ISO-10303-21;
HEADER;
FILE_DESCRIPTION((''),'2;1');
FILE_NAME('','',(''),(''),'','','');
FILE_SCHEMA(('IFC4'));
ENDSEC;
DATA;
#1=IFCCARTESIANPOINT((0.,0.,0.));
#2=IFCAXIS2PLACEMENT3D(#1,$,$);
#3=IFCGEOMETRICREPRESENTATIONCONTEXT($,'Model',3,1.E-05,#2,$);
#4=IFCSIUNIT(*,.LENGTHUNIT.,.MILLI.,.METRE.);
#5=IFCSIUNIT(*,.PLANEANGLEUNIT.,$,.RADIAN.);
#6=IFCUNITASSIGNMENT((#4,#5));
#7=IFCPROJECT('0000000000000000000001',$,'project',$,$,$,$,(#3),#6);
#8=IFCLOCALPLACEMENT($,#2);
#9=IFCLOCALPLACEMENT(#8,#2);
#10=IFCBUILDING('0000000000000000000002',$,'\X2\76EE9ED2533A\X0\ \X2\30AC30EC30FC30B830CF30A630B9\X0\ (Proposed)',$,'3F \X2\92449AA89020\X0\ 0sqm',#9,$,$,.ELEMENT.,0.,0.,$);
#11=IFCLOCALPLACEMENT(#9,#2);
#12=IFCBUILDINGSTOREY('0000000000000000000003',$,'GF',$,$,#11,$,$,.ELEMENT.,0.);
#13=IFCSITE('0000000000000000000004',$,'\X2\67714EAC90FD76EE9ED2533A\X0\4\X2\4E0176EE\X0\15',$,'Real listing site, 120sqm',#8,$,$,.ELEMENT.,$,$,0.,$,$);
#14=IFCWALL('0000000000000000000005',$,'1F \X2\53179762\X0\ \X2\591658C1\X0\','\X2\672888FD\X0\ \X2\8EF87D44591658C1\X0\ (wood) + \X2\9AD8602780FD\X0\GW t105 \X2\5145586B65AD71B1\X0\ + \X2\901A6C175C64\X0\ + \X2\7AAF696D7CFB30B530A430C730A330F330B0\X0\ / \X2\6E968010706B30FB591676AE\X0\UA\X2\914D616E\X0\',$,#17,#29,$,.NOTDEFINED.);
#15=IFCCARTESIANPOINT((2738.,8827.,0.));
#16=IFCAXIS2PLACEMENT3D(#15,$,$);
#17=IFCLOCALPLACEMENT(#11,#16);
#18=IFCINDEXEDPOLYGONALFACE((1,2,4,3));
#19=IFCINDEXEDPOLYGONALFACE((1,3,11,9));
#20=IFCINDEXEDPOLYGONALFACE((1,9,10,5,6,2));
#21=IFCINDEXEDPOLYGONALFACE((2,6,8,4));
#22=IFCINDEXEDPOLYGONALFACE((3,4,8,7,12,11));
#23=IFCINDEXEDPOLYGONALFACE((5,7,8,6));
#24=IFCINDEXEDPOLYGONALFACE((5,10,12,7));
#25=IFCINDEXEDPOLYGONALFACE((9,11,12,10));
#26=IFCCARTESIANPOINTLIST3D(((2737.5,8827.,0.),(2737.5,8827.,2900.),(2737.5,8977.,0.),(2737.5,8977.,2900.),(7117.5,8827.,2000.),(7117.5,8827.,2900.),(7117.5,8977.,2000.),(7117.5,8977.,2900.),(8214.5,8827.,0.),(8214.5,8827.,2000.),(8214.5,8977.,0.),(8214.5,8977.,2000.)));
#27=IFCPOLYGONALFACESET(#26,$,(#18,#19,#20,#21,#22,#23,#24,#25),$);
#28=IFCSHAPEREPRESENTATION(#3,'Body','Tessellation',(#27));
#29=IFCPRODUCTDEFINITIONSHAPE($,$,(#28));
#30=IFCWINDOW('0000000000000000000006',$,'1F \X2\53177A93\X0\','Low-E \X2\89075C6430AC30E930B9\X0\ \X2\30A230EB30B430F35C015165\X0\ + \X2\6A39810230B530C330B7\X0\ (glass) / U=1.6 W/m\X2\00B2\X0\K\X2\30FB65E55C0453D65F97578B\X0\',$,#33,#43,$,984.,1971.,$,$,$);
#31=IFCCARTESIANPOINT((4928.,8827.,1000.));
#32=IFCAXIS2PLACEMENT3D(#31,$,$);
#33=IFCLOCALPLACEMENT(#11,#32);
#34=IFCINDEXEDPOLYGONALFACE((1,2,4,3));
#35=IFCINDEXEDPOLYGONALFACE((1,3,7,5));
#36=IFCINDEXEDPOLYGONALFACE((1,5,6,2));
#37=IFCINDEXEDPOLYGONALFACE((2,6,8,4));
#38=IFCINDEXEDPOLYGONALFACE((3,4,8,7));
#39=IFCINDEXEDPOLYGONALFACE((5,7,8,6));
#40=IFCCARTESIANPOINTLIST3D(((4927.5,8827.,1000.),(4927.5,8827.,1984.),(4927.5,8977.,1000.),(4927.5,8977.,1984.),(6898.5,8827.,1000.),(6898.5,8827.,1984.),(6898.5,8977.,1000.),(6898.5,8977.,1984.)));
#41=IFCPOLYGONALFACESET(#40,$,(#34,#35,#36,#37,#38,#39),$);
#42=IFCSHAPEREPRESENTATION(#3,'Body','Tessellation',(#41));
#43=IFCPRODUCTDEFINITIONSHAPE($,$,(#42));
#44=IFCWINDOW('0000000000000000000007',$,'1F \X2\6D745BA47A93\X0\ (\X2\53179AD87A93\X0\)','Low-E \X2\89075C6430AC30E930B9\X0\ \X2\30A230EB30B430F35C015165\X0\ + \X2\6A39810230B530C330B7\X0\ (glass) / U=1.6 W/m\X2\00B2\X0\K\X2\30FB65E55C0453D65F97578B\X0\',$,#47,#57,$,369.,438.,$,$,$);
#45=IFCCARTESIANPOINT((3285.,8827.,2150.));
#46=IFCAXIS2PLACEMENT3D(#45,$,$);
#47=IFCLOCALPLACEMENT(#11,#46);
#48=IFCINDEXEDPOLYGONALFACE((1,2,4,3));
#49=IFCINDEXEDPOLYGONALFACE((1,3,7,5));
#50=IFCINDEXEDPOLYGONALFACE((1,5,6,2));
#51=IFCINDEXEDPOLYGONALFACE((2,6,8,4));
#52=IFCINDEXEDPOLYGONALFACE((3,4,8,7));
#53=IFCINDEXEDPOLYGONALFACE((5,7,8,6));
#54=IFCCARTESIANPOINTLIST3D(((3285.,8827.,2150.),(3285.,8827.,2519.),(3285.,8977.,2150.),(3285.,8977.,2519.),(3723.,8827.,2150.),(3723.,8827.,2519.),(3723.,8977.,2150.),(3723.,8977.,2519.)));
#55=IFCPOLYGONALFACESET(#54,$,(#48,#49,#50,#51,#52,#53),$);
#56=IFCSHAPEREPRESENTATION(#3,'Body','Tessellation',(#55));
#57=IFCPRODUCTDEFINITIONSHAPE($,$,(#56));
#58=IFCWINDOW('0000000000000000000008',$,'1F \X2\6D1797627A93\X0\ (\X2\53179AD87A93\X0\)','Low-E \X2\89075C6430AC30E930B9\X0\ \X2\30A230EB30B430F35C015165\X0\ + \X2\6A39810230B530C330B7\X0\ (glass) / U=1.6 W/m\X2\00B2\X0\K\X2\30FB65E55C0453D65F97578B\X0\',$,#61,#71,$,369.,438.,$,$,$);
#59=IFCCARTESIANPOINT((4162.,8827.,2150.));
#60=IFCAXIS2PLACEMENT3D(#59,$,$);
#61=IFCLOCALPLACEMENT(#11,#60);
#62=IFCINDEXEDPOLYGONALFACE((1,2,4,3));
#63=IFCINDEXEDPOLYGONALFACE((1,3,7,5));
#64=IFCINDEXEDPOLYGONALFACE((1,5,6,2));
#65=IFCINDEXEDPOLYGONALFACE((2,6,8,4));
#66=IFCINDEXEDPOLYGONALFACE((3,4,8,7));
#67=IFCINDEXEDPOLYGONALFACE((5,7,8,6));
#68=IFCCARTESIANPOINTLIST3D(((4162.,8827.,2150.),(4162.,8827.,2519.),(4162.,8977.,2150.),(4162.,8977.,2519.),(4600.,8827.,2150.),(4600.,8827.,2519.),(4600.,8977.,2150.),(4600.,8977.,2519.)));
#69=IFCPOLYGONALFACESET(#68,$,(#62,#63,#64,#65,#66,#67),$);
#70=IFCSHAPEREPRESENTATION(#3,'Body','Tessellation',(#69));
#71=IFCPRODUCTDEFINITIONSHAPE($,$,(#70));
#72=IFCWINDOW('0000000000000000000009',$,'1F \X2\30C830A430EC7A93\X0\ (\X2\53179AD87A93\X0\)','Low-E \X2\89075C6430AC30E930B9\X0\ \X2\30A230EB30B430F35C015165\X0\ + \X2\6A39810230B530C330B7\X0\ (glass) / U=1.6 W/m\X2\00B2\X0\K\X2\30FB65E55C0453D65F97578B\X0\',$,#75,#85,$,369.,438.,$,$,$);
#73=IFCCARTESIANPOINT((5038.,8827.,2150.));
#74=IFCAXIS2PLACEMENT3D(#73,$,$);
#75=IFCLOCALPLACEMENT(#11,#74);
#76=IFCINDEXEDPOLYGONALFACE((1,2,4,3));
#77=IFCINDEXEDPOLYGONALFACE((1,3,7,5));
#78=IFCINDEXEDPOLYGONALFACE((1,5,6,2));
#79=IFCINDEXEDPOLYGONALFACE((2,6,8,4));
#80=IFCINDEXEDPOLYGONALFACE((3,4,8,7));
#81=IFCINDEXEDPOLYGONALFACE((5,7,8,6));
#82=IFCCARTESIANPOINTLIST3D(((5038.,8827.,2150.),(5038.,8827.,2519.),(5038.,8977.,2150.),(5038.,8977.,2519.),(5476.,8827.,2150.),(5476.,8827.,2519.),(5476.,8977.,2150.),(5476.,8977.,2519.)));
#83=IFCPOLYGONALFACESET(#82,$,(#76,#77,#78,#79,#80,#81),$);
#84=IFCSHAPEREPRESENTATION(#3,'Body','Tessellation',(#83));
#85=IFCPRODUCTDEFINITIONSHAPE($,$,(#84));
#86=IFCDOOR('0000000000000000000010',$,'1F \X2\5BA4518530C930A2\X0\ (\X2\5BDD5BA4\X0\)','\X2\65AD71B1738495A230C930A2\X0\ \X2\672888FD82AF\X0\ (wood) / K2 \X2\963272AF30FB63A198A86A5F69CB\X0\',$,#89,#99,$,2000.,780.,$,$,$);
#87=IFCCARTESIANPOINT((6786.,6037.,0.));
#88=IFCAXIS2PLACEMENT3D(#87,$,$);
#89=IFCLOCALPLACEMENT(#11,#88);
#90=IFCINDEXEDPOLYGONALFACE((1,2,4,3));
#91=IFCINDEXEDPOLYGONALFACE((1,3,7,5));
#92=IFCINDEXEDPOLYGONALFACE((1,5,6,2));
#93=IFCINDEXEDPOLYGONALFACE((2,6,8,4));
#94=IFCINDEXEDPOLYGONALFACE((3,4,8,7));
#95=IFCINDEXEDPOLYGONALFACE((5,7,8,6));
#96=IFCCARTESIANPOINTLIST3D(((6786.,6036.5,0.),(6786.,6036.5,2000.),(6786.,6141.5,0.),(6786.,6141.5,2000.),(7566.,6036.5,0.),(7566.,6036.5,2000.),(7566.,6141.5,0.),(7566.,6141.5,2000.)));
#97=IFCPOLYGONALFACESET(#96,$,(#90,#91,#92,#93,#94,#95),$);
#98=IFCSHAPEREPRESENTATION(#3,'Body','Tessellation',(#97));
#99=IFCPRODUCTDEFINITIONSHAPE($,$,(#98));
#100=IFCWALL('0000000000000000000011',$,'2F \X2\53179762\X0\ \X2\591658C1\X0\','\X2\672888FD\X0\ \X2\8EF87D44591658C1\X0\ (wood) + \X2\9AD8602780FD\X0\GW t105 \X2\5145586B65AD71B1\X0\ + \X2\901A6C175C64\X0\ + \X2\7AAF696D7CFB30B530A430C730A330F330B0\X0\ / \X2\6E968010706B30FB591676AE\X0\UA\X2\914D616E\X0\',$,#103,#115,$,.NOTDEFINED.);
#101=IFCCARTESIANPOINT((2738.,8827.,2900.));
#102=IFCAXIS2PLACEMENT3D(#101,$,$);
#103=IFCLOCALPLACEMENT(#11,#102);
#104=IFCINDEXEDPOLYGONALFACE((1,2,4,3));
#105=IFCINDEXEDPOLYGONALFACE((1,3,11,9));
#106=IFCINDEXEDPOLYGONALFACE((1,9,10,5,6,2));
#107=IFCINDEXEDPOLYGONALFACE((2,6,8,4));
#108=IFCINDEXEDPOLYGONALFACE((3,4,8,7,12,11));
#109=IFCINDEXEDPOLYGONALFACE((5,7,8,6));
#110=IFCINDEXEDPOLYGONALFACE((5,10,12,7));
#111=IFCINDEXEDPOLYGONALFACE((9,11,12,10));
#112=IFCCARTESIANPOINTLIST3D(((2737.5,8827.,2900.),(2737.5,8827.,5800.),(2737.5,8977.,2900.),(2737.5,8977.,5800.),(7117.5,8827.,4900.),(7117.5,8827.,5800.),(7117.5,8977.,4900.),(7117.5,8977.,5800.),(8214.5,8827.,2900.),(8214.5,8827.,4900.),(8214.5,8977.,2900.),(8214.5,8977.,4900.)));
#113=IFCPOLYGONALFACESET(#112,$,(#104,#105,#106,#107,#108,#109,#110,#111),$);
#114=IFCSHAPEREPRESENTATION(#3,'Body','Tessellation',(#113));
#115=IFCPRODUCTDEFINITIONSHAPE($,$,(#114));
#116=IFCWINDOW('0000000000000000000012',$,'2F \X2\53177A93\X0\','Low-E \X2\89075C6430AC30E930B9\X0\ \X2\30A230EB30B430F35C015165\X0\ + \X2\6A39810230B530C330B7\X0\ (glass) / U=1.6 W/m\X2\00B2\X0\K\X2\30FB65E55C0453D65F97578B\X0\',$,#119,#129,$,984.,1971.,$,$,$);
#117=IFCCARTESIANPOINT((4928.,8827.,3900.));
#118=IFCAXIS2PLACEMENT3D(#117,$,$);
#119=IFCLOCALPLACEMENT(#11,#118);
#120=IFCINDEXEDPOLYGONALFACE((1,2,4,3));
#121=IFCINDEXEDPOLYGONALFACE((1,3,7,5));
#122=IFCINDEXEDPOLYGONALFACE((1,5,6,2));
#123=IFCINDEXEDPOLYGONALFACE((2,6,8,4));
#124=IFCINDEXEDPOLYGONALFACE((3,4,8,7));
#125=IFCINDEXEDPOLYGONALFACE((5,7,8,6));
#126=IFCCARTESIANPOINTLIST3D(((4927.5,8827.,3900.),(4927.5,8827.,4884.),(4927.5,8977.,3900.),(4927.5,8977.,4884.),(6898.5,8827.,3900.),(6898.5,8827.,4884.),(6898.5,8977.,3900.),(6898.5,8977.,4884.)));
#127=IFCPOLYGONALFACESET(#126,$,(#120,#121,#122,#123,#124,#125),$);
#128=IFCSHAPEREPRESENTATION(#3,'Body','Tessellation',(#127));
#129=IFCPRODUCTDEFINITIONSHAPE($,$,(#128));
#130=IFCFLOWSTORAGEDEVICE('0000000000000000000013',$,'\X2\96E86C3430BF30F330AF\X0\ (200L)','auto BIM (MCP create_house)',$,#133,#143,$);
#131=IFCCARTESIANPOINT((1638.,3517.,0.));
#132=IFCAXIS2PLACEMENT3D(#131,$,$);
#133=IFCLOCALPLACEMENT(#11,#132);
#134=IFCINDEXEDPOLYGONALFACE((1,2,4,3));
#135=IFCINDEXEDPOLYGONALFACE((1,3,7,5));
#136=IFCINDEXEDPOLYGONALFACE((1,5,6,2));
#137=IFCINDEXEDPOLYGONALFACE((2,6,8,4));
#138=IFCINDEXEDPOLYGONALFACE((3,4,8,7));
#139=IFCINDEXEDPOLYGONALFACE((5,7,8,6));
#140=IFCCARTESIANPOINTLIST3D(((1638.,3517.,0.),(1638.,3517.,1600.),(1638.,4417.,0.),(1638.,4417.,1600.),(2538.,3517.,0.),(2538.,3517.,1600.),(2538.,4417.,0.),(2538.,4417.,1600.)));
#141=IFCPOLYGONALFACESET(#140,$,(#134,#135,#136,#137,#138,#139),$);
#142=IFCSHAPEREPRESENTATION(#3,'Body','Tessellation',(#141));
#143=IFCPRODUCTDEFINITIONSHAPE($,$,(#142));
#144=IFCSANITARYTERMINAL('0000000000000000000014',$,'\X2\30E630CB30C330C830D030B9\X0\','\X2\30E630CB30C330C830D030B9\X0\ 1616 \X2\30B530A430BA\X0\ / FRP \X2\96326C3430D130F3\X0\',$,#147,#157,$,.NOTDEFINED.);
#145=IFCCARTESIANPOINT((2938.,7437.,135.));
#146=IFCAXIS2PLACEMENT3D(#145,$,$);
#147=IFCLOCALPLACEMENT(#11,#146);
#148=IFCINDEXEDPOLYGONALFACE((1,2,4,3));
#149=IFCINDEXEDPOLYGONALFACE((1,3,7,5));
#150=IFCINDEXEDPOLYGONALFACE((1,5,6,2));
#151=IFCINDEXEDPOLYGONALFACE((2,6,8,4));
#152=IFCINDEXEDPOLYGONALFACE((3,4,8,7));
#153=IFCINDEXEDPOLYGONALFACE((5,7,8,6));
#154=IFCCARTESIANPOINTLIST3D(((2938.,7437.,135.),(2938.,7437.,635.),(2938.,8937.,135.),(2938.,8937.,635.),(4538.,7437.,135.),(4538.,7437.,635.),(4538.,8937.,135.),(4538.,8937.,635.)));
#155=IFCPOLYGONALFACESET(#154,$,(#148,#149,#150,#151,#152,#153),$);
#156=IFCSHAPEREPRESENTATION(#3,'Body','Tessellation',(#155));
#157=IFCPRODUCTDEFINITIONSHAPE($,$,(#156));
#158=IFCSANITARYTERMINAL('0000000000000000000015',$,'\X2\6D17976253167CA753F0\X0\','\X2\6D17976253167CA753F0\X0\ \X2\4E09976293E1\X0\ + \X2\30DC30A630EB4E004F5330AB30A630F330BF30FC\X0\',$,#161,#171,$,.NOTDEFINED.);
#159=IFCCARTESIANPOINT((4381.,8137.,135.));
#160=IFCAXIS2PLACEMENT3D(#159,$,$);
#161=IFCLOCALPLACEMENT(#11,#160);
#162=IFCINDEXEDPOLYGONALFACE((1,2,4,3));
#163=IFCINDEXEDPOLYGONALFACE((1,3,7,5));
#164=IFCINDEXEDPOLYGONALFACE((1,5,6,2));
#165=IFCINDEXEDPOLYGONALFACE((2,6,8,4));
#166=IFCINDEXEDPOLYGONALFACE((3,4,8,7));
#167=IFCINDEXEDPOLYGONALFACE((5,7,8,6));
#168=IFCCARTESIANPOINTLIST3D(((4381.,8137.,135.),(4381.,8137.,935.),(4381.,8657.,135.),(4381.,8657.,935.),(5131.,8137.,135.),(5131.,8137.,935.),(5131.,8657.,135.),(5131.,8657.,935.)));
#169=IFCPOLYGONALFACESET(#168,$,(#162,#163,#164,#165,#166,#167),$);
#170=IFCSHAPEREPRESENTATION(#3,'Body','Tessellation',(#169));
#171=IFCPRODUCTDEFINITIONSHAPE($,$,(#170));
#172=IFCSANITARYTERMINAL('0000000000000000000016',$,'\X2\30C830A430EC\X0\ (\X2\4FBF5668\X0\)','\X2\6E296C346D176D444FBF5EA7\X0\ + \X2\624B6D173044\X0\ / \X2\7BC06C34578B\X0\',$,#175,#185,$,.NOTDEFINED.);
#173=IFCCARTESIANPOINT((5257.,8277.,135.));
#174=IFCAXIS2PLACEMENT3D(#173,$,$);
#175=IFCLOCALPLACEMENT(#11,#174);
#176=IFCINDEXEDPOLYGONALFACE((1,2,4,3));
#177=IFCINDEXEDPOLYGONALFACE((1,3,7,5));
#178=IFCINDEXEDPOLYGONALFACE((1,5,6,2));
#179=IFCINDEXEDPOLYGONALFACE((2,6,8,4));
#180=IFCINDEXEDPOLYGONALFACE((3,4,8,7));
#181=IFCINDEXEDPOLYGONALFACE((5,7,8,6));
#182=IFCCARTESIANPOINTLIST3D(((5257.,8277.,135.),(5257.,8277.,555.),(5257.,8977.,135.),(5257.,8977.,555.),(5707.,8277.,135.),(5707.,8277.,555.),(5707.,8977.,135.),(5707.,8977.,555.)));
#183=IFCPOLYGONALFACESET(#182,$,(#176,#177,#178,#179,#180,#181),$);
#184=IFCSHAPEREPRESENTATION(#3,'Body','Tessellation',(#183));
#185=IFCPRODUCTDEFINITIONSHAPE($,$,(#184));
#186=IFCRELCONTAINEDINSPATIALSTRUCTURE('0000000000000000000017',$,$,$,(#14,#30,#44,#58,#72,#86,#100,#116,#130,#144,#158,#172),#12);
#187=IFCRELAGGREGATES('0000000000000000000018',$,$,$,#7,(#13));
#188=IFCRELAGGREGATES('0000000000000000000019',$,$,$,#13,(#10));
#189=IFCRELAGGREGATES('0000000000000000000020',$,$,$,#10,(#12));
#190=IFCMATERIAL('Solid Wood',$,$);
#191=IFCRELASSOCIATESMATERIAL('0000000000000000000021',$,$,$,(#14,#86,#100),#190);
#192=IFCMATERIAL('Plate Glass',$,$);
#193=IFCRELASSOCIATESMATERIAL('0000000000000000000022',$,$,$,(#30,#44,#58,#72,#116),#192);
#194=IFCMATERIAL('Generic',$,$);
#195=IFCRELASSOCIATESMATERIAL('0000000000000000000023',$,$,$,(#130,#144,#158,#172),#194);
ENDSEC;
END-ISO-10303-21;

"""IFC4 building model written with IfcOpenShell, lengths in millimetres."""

from ifc_helpers import new_model, si_unit, frame, frame_2d, origin, place, context, project, spatial, rectangle, extrude, material, element, fill, save


model = new_model("IFC4")

# Units and contexts
model_context = context("Model", 3, precision=1e-05, world=origin())
ifc_project = project(units=[si_unit("LENGTHUNIT", "METRE", prefix="MILLI"), si_unit("PLANEANGLEUNIT", "RADIAN")], contexts=[model_context])

# Site, building, storey
site_placement = place(None, origin())
site = spatial("IfcSite", under=ifc_project, at=site_placement, Name="東京都目黒区4丁目15", ObjectType="Real listing site, 120sqm", CompositionType="ELEMENT", RefElevation=0.0)
building_placement = place(site_placement, origin())
building = spatial("IfcBuilding", under=site, at=building_placement, Name="目黒区 ガレージハウス (Proposed)", ObjectType="3F 鉄骨造 0sqm", CompositionType="ELEMENT", ElevationOfRefHeight=0.0, ElevationOfTerrain=0.0)
storey_placement = place(building_placement, origin())
storey = spatial("IfcBuildingStorey", under=building, at=storey_placement, Name="GF", CompositionType="ELEMENT", Elevation=0.0)

# Wall, openings, windows
ifc_material_1 = material(Name="Solid Wood")
wall_1_placement = place(storey_placement, frame((2738.0, 8827.0, 0.0)))
wall_1 = element("IfcWall", 1, at=wall_1_placement, inside=storey, material=ifc_material_1, Name="1F 北面 外壁", Description="木製 軸組外壁 (wood) + 高性能GW t105 充填断熱 + 通気層 + 窯業系サイディング / 準耐火・外皮UA配慮", PredefinedType="NOTDEFINED", context=model_context, shape_type="SweptSolid", body=[
    extrude(rectangle(XDim=5477.0, YDim=150.0, at=frame_2d((2738.0, 75.0))), frame((2738.0, 8827.0, 0.0)), (0.0, 0.0, 1.0), 2900.0),
])
opening_1_placement = place(storey_placement, frame((4928.0, 8827.0, 1000.0)))
opening_1 = element("IfcOpeningElement", 2, at=opening_1_placement, cuts=wall_1, PredefinedType="NOTDEFINED", context=model_context, shape_type="SweptSolid", body=[
    extrude(rectangle(XDim=1971.0, YDim=150.0, at=frame_2d((985.0, 75.0))), frame((4928.0, 8827.0, 1000.0)), (0.0, 0.0, 1.0), 984.0),
])
opening_2_placement = place(storey_placement, frame((3285.0, 8827.0, 2150.0)))
opening_2 = element("IfcOpeningElement", 3, at=opening_2_placement, cuts=wall_1, PredefinedType="NOTDEFINED", context=model_context, shape_type="SweptSolid", body=[
    extrude(rectangle(XDim=438.0, YDim=150.0, at=frame_2d((219.0, 75.0))), frame((3285.0, 8827.0, 2150.0)), (0.0, 0.0, 1.0), 369.0),
])
opening_3_placement = place(storey_placement, frame((4162.0, 8827.0, 2150.0)))
opening_3 = element("IfcOpeningElement", 4, at=opening_3_placement, cuts=wall_1, PredefinedType="NOTDEFINED", context=model_context, shape_type="SweptSolid", body=[
    extrude(rectangle(XDim=438.0, YDim=150.0, at=frame_2d((219.0, 75.0))), frame((4162.0, 8827.0, 2150.0)), (0.0, 0.0, 1.0), 369.0),
])
opening_4_placement = place(storey_placement, frame((5038.0, 8827.0, 2150.0)))
opening_4 = element("IfcOpeningElement", 5, at=opening_4_placement, cuts=wall_1, PredefinedType="NOTDEFINED", context=model_context, shape_type="SweptSolid", body=[
    extrude(rectangle(XDim=438.0, YDim=150.0, at=frame_2d((219.0, 75.0))), frame((5038.0, 8827.0, 2150.0)), (0.0, 0.0, 1.0), 369.0),
])
ifc_material_2 = material(Name="Plate Glass")
window_1_placement = place(storey_placement, frame((4928.0, 8827.0, 1000.0)))
window_1 = element("IfcWindow", 6, at=window_1_placement, inside=storey, material=ifc_material_2, Name="1F 北窓", Description="Low-E 複層ガラス アルゴン封入 + 樹脂サッシ (glass) / U=1.6 W/m²K・日射取得型", OverallHeight=984.0, OverallWidth=1971.0, context=model_context, shape_type="SweptSolid", body=[
    extrude(rectangle(XDim=1971.0, YDim=150.0, at=frame_2d((985.0, 75.0))), frame((4928.0, 8827.0, 1000.0)), (0.0, 0.0, 1.0), 984.0),
])
fill(opening_1, window_1)
window_2_placement = place(storey_placement, frame((3285.0, 8827.0, 2150.0)))
window_2 = element("IfcWindow", 7, at=window_2_placement, inside=storey, material=ifc_material_2, Name="1F 浴室窓 (北高窓)", Description="Low-E 複層ガラス アルゴン封入 + 樹脂サッシ (glass) / U=1.6 W/m²K・日射取得型", OverallHeight=369.0, OverallWidth=438.0, context=model_context, shape_type="SweptSolid", body=[
    extrude(rectangle(XDim=438.0, YDim=150.0, at=frame_2d((219.0, 75.0))), frame((3285.0, 8827.0, 2150.0)), (0.0, 0.0, 1.0), 369.0),
])
fill(opening_2, window_2)
window_3_placement = place(storey_placement, frame((4162.0, 8827.0, 2150.0)))
window_3 = element("IfcWindow", 8, at=window_3_placement, inside=storey, material=ifc_material_2, Name="1F 洗面窓 (北高窓)", Description="Low-E 複層ガラス アルゴン封入 + 樹脂サッシ (glass) / U=1.6 W/m²K・日射取得型", OverallHeight=369.0, OverallWidth=438.0, context=model_context, shape_type="SweptSolid", body=[
    extrude(rectangle(XDim=438.0, YDim=150.0, at=frame_2d((219.0, 75.0))), frame((4162.0, 8827.0, 2150.0)), (0.0, 0.0, 1.0), 369.0),
])
fill(opening_3, window_3)
window_4_placement = place(storey_placement, frame((5038.0, 8827.0, 2150.0)))
window_4 = element("IfcWindow", 9, at=window_4_placement, inside=storey, material=ifc_material_2, Name="1F トイレ窓 (北高窓)", Description="Low-E 複層ガラス アルゴン封入 + 樹脂サッシ (glass) / U=1.6 W/m²K・日射取得型", OverallHeight=369.0, OverallWidth=438.0, context=model_context, shape_type="SweptSolid", body=[
    extrude(rectangle(XDim=438.0, YDim=150.0, at=frame_2d((219.0, 75.0))), frame((5038.0, 8827.0, 2150.0)), (0.0, 0.0, 1.0), 369.0),
])
fill(opening_4, window_4)

# Door
door_1_placement = place(storey_placement, frame((6786.0, 6037.0, 0.0)))
element("IfcDoor", 10, at=door_1_placement, inside=storey, material=ifc_material_1, Name="1F 室内ドア (寝室)", Description="断熱玄関ドア 木製芯 (wood) / K2 防犯・採風機構", OverallHeight=2000.0, OverallWidth=780.0, context=model_context, shape_type="SweptSolid", body=[
    extrude(rectangle(XDim=780.0, YDim=105.0, at=frame_2d((390.0, 52.0))), frame((6786.0, 6037.0, 0.0)), (0.0, 0.0, 1.0), 2000.0),
])

# Wall, opening, window
wall_2_placement = place(storey_placement, frame((2738.0, 8827.0, 2900.0)))
wall_2 = element("IfcWall", 11, at=wall_2_placement, inside=storey, material=ifc_material_1, Name="2F 北面 外壁", Description="木製 軸組外壁 (wood) + 高性能GW t105 充填断熱 + 通気層 + 窯業系サイディング / 準耐火・外皮UA配慮", PredefinedType="NOTDEFINED", context=model_context, shape_type="SweptSolid", body=[
    extrude(rectangle(XDim=5477.0, YDim=150.0, at=frame_2d((2738.0, 75.0))), frame((2738.0, 8827.0, 2900.0)), (0.0, 0.0, 1.0), 2900.0),
])
opening_5_placement = place(storey_placement, frame((4928.0, 8827.0, 3900.0)))
opening_5 = element("IfcOpeningElement", 12, at=opening_5_placement, cuts=wall_2, PredefinedType="NOTDEFINED", context=model_context, shape_type="SweptSolid", body=[
    extrude(rectangle(XDim=1971.0, YDim=150.0, at=frame_2d((985.0, 75.0))), frame((4928.0, 8827.0, 3900.0)), (0.0, 0.0, 1.0), 984.0),
])
window_5_placement = place(storey_placement, frame((4928.0, 8827.0, 3900.0)))
window_5 = element("IfcWindow", 13, at=window_5_placement, inside=storey, material=ifc_material_2, Name="2F 北窓", Description="Low-E 複層ガラス アルゴン封入 + 樹脂サッシ (glass) / U=1.6 W/m²K・日射取得型", OverallHeight=984.0, OverallWidth=1971.0, context=model_context, shape_type="SweptSolid", body=[
    extrude(rectangle(XDim=1971.0, YDim=150.0, at=frame_2d((985.0, 75.0))), frame((4928.0, 8827.0, 3900.0)), (0.0, 0.0, 1.0), 984.0),
])
fill(opening_5, window_5)

# Flow storage device
ifc_material_3 = material(Name="Generic")
flow_storage_device_placement = place(storey_placement, frame((1638.0, 3517.0, 0.0)))
element("IfcFlowStorageDevice", 14, at=flow_storage_device_placement, inside=storey, material=ifc_material_3, Name="雨水タンク (200L)", Description="auto BIM (MCP create_house)", context=model_context, shape_type="SweptSolid", body=[
    extrude(rectangle(XDim=900.0, YDim=900.0, at=frame_2d((450.0, 450.0))), frame((1638.0, 3517.0, 0.0)), (0.0, 0.0, 1.0), 1600.0),
])

# Sanitary terminals
sanitary_terminal_1_placement = place(storey_placement, frame((2938.0, 7437.0, 135.0)))
element("IfcSanitaryTerminal", 15, at=sanitary_terminal_1_placement, inside=storey, material=ifc_material_3, Name="ユニットバス", Description="ユニットバス 1616 サイズ / FRP 防水パン", PredefinedType="NOTDEFINED", context=model_context, shape_type="SweptSolid", body=[
    extrude(rectangle(XDim=1600.0, YDim=1500.0, at=frame_2d((800.0, 750.0))), frame((2938.0, 7437.0, 135.0)), (0.0, 0.0, 1.0), 500.0),
])
sanitary_terminal_2_placement = place(storey_placement, frame((4381.0, 8137.0, 135.0)))
element("IfcSanitaryTerminal", 16, at=sanitary_terminal_2_placement, inside=storey, material=ifc_material_3, Name="洗面化粧台", Description="洗面化粧台 三面鏡 + ボウル一体カウンター", PredefinedType="NOTDEFINED", context=model_context, shape_type="SweptSolid", body=[
    extrude(rectangle(XDim=750.0, YDim=520.0, at=frame_2d((375.0, 260.0))), frame((4381.0, 8137.0, 135.0)), (0.0, 0.0, 1.0), 800.0),
])
sanitary_terminal_3_placement = place(storey_placement, frame((5257.0, 8277.0, 135.0)))
element("IfcSanitaryTerminal", 17, at=sanitary_terminal_3_placement, inside=storey, material=ifc_material_3, Name="トイレ (便器)", Description="温水洗浄便座 + 手洗い / 節水型", PredefinedType="NOTDEFINED", context=model_context, shape_type="SweptSolid", body=[
    extrude(rectangle(XDim=450.0, YDim=700.0, at=frame_2d((225.0, 350.0))), frame((5257.0, 8277.0, 135.0)), (0.0, 0.0, 1.0), 420.0),
])

save(model, "model.ifc")
